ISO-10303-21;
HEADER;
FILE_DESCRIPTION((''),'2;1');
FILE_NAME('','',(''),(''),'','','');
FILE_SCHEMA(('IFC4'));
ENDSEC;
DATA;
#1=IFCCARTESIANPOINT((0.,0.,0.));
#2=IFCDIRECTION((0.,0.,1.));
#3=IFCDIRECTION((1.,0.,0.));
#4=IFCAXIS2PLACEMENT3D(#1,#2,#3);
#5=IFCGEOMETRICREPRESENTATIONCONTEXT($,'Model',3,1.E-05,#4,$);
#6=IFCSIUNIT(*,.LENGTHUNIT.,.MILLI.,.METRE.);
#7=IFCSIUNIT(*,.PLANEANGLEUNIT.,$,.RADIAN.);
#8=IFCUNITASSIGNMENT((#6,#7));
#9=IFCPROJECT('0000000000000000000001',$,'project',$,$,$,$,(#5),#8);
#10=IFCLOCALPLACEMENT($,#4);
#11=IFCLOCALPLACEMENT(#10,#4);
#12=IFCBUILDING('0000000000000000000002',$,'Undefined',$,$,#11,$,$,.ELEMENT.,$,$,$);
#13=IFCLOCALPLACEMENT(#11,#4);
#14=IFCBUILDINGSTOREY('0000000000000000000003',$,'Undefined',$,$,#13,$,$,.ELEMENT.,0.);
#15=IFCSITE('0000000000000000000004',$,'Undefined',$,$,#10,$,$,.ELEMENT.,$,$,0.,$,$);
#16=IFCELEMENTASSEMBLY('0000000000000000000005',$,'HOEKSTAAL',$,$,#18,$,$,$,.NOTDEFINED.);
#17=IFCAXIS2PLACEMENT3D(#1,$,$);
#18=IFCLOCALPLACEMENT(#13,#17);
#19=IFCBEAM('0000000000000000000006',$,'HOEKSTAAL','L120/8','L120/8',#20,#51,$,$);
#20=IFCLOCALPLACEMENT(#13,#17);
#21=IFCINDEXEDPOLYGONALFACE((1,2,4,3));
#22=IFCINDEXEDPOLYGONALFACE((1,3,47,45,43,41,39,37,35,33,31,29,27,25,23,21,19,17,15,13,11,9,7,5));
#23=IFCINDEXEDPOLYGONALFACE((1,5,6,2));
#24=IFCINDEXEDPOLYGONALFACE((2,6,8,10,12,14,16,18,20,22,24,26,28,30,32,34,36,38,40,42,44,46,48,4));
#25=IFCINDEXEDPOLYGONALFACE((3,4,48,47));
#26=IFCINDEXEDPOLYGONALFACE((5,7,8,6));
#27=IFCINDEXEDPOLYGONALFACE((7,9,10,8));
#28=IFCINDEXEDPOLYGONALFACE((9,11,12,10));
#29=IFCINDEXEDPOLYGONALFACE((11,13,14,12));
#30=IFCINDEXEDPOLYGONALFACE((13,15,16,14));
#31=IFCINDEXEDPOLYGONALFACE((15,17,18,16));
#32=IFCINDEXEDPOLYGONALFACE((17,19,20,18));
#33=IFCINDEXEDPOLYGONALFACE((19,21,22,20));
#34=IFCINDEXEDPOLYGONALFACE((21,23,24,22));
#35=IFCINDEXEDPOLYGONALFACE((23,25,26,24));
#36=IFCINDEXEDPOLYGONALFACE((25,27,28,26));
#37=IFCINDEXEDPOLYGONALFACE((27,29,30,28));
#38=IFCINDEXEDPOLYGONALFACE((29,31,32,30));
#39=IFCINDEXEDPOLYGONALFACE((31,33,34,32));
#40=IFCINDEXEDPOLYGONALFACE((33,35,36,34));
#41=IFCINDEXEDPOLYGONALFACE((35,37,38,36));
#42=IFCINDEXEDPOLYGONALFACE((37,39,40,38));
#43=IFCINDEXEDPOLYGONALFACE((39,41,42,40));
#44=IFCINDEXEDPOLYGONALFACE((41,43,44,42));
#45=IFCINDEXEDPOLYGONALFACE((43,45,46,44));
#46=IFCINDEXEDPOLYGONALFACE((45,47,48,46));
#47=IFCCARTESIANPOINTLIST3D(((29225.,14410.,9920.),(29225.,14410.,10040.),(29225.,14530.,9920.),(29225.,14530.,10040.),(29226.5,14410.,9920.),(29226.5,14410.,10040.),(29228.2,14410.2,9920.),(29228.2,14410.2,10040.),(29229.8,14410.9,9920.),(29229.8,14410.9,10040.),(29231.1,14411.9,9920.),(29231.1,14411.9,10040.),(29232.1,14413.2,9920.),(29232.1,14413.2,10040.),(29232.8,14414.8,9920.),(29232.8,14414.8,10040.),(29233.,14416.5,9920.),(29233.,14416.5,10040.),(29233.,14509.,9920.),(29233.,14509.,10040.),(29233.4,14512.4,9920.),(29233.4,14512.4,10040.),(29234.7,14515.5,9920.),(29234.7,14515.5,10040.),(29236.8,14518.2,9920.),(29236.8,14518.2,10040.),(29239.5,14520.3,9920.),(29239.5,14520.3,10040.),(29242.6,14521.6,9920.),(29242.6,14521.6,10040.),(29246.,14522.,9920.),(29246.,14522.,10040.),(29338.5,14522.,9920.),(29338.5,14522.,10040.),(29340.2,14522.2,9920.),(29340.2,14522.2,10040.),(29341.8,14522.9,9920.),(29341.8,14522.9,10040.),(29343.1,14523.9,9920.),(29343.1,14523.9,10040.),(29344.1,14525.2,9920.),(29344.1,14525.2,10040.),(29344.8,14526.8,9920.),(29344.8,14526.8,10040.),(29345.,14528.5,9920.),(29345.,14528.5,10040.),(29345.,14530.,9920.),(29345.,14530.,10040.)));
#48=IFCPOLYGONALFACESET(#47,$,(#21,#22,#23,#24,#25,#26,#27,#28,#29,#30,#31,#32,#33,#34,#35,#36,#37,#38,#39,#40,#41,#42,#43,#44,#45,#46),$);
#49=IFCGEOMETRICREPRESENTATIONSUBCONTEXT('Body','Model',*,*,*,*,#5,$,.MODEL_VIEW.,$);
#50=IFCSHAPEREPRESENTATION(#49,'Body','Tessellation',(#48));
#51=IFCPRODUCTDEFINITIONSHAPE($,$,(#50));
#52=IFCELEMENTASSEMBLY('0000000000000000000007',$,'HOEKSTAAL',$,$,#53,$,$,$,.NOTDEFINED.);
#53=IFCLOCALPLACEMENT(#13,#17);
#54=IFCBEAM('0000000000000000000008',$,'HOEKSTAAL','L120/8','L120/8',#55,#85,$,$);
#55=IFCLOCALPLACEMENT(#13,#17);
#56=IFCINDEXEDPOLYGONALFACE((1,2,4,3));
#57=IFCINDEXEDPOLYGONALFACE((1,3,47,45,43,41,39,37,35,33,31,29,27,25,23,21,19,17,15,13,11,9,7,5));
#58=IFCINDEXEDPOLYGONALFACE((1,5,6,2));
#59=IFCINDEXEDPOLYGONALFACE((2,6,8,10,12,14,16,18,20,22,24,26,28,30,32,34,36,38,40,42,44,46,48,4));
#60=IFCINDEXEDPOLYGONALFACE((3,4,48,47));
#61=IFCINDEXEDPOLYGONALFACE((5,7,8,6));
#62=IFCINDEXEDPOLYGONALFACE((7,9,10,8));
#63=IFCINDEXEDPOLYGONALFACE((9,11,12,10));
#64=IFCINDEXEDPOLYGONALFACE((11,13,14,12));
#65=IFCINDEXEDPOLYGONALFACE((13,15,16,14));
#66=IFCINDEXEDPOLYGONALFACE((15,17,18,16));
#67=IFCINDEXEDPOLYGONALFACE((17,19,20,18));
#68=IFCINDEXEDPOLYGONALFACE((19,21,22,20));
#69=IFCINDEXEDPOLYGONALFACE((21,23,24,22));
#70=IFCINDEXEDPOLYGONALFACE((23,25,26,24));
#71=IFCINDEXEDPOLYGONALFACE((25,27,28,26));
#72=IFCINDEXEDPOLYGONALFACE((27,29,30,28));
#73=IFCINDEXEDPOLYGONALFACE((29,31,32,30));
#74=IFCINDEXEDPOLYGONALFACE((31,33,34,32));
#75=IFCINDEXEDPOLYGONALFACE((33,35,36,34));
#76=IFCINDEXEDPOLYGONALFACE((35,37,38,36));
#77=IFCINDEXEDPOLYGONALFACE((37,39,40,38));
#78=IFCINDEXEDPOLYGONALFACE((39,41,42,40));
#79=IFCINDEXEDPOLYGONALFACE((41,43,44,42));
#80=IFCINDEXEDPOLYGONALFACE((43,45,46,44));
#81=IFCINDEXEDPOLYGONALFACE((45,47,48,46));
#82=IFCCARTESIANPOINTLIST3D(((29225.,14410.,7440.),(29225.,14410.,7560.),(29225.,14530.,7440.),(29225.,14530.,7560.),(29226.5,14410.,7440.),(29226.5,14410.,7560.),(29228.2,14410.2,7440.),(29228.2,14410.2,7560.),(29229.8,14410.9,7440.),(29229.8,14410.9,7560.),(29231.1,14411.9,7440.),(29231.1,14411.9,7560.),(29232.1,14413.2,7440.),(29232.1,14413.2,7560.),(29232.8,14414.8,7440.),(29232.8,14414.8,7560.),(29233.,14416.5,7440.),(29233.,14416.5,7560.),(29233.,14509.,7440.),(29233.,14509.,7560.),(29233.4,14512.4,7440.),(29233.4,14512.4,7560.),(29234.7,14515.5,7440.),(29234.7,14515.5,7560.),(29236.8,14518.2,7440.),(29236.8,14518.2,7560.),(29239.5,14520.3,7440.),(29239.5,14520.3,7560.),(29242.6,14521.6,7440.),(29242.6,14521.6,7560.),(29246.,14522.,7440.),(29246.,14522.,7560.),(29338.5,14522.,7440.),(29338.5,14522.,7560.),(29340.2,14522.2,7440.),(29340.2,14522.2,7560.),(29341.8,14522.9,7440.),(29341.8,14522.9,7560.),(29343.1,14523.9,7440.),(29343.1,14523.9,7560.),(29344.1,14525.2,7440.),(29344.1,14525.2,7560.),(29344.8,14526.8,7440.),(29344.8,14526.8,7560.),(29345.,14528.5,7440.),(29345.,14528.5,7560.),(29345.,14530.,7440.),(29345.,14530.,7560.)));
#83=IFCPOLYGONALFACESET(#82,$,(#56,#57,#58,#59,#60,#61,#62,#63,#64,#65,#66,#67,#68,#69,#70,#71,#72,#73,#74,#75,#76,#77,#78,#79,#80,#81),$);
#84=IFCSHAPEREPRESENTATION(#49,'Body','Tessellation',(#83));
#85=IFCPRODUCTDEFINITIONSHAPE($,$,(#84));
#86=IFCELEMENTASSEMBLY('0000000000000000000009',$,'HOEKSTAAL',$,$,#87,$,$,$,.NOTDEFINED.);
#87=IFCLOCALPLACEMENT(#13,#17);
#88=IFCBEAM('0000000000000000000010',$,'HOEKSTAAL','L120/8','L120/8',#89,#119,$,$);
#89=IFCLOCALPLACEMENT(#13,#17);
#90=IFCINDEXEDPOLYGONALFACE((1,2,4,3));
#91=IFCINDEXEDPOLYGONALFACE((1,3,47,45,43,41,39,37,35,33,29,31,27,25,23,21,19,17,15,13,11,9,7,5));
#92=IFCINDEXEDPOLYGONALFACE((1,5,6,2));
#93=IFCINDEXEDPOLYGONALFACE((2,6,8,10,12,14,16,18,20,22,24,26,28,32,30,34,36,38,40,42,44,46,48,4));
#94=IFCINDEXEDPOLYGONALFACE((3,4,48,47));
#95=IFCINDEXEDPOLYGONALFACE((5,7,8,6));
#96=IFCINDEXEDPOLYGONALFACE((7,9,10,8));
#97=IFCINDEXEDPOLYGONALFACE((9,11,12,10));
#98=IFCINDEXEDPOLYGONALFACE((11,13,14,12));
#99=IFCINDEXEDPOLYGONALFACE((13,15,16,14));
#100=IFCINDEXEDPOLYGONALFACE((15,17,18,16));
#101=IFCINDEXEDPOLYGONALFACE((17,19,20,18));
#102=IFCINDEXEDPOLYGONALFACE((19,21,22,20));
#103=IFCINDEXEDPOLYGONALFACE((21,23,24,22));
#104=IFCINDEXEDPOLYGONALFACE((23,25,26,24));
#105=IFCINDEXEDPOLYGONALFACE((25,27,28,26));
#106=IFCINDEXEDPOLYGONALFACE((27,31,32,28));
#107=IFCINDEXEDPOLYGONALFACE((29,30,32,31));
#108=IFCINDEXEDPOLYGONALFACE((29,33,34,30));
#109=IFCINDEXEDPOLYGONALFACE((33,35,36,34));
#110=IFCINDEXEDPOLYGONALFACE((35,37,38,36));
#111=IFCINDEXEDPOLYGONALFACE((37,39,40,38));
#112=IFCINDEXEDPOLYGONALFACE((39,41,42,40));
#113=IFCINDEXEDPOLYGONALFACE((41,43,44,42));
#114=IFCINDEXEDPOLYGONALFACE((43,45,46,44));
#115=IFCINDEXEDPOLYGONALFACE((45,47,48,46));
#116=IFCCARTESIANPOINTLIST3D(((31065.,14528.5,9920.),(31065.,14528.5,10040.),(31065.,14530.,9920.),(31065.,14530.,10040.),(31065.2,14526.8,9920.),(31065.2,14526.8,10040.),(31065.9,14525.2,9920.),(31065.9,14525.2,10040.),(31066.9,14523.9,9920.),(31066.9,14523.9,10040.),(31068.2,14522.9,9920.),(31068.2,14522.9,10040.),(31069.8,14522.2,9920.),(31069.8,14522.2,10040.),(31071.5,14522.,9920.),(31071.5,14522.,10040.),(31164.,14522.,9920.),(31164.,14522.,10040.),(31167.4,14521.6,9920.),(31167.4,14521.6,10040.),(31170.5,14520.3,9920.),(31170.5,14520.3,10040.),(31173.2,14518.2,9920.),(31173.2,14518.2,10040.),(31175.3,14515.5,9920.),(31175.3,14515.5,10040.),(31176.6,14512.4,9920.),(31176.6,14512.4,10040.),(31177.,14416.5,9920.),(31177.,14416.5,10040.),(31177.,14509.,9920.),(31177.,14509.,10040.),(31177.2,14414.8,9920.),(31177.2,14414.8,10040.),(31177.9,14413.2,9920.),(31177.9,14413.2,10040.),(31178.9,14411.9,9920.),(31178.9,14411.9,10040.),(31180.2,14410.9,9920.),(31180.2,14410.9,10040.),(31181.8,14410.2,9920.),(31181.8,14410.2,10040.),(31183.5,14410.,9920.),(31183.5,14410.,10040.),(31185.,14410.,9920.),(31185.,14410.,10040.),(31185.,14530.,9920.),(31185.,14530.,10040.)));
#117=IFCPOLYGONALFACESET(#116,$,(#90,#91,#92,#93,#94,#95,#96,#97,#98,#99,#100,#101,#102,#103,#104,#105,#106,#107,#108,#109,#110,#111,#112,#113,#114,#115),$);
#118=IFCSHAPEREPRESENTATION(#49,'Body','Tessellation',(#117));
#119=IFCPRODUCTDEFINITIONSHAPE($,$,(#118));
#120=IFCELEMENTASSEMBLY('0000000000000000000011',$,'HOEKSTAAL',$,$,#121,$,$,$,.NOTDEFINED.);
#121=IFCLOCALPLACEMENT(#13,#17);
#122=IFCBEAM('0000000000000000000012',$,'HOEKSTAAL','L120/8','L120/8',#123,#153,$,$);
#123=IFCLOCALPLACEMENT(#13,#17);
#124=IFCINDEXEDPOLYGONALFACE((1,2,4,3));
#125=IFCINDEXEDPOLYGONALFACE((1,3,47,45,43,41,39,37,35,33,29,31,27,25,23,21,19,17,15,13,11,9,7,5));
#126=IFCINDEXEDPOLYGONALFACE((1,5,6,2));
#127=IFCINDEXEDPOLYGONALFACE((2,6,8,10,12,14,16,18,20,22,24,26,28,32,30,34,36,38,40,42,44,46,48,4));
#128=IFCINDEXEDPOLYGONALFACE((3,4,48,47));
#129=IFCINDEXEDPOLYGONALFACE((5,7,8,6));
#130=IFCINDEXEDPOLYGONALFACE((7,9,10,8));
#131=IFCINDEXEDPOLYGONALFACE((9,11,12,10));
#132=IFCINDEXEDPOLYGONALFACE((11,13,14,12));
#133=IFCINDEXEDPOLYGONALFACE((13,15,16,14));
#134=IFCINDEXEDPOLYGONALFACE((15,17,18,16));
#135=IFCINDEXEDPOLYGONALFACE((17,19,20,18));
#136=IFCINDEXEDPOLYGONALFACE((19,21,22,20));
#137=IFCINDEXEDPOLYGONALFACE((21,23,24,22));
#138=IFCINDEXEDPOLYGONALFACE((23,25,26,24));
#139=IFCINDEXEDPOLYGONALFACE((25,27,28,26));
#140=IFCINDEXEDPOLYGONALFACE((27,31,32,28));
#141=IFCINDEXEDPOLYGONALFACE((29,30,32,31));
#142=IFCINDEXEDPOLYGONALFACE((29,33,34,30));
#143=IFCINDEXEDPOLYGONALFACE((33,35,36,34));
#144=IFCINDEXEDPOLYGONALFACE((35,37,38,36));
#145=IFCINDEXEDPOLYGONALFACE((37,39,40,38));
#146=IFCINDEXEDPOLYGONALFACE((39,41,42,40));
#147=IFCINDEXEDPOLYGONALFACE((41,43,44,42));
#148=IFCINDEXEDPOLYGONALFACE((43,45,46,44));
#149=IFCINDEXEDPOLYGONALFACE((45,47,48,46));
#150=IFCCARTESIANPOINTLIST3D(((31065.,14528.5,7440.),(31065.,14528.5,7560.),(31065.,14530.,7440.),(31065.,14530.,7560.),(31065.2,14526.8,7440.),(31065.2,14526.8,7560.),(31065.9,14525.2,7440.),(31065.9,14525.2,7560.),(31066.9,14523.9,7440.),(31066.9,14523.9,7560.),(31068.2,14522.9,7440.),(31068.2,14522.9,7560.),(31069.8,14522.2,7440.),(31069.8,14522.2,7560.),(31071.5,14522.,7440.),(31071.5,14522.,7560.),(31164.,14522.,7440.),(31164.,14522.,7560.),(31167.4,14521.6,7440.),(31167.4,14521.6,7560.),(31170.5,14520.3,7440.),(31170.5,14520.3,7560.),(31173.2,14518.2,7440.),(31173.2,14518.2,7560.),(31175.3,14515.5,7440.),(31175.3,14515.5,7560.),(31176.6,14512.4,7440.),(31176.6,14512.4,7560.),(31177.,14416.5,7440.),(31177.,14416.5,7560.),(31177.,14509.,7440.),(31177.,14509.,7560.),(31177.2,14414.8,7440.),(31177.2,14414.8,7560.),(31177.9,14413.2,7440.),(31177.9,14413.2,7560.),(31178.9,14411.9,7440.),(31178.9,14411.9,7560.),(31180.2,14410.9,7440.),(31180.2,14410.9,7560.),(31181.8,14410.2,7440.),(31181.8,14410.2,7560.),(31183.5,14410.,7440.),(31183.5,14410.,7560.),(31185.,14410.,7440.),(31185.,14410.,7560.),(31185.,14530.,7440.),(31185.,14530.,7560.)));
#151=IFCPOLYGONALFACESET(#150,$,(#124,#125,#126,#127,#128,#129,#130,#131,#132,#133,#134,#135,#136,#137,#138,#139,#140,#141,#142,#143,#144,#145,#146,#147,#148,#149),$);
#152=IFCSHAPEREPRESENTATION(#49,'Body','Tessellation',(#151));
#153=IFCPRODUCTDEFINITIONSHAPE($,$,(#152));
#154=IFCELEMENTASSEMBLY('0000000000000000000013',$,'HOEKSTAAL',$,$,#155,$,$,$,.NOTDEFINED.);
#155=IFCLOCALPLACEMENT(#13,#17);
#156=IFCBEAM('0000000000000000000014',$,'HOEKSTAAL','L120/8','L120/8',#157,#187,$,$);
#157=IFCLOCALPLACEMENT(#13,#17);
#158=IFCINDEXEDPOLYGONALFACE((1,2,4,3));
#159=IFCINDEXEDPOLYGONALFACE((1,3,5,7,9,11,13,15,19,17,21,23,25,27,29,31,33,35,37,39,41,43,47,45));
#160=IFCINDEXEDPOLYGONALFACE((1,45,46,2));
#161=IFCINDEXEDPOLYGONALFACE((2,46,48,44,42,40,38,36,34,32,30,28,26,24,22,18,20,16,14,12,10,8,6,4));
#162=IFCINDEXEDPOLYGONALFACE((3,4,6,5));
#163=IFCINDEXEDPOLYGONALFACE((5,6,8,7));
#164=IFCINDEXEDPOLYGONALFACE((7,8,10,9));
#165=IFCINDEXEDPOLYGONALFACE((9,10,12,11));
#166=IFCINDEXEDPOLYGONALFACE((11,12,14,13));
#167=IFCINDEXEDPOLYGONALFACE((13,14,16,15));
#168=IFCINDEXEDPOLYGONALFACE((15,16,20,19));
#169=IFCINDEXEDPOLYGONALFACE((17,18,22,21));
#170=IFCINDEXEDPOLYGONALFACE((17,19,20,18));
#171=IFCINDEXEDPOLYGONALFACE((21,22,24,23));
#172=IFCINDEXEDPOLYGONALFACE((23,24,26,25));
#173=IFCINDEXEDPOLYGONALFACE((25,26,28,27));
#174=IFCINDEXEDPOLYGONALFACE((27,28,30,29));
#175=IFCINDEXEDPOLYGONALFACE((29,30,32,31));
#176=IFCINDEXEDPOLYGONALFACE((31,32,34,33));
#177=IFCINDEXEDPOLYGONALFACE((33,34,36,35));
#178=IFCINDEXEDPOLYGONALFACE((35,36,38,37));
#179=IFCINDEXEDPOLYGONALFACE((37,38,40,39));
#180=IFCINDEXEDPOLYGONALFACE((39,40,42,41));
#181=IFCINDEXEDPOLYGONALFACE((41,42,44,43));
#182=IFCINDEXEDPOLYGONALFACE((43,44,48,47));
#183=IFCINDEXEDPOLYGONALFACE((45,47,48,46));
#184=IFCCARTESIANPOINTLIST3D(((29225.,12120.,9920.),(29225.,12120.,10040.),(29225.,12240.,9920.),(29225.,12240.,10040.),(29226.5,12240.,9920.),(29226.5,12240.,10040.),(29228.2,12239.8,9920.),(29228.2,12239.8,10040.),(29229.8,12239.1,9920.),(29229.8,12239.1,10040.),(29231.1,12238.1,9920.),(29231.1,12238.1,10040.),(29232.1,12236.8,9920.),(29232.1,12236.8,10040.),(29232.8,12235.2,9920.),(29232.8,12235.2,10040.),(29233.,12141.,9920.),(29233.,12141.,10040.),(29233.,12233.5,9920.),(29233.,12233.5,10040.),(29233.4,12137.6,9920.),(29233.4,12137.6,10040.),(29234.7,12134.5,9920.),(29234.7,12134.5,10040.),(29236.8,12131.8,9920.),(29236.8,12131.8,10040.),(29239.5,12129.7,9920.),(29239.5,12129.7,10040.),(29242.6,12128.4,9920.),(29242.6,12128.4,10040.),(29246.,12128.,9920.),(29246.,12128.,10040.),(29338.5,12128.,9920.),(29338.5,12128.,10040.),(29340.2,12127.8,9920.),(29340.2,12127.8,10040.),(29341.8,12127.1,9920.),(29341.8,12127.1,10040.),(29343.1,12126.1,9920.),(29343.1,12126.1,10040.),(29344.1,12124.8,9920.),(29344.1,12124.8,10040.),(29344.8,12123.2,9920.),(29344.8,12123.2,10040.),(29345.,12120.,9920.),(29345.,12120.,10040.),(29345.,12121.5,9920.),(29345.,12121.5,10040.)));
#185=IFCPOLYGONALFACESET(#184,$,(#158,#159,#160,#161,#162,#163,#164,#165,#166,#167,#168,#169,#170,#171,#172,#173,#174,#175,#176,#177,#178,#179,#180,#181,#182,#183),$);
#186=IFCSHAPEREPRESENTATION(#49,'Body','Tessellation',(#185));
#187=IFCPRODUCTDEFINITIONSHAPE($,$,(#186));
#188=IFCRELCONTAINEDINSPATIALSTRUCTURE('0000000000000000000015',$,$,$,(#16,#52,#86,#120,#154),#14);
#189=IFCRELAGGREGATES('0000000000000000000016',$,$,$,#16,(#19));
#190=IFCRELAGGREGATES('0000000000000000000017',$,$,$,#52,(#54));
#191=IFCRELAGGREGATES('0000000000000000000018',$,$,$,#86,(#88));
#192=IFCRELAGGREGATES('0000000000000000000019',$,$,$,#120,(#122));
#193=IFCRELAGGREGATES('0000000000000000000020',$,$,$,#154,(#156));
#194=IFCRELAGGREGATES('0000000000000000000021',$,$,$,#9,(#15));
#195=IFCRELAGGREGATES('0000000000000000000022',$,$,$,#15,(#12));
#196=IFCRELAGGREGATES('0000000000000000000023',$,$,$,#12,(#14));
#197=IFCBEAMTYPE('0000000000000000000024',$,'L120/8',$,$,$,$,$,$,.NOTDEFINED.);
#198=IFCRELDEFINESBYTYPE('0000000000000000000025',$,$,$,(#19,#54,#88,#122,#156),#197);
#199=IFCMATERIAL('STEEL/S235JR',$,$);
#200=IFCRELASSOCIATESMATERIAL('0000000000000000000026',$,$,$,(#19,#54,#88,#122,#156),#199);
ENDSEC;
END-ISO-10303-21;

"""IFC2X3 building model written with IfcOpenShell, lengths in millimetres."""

from ifc_helpers import new_model, si_unit, frame, origin_with_axes, origin_2d_with_axis, place, context, subcontext, project, spatial, l_section, extrude, material, type_object, element, aggregate, save


model = new_model("IFC2X3")

# Units and contexts
model_context = context("Model", 3, precision=1e-05, world=origin_with_axes())
body_context = subcontext(model_context, "Body", "Model", "MODEL_VIEW")
ifc_project = project(units=[si_unit("LENGTHUNIT", "METRE", prefix="MILLI"), si_unit("PLANEANGLEUNIT", "RADIAN")], contexts=[model_context])

# Site, building, storey
site_placement = place(None, origin_with_axes())
site = spatial("IfcSite", under=ifc_project, at=site_placement, Name="Undefined", CompositionType="ELEMENT", RefElevation=0.0)
building_placement = place(site_placement, origin_with_axes())
building = spatial("IfcBuilding", under=site, at=building_placement, Name="Undefined", CompositionType="ELEMENT")
storey_placement = place(building_placement, origin_with_axes())
storey = spatial("IfcBuildingStorey", under=building, at=storey_placement, Name="Undefined", CompositionType="ELEMENT", Elevation=0.0)

# Element assemblies, beams
assembly_1_placement = place(storey_placement, origin_with_axes())
assembly_1 = element("IfcElementAssembly", 1, at=assembly_1_placement, inside=storey, Name="HOEKSTAAL", PredefinedType="NOTDEFINED")
ifc_material_1 = material(Name="STEEL/S235JR")
beam_type_1 = type_object("IfcBeamType", Name="L120/8", PredefinedType="NOTDEFINED")
beam_1_placement = place(assembly_1_placement, frame((29285.0, 14470.0, 10040.0), z_axis=(1.0, 0.0, 0.0), x_axis=(0.0, 0.0, -1.0)))
beam_1 = element("IfcBeam", 2, at=beam_1_placement, type_object=beam_type_1, material=ifc_material_1, Name="HOEKSTAAL", Description="L120/8", ObjectType="L120/8", context=body_context, shape_type="SweptSolid", body=[
    extrude(l_section(Depth=120.0, Width=120.0, Thickness=8.0, FilletRadius=13.0, EdgeRadius=6.5, at=origin_2d_with_axis()), frame((120.0, 0.0, 0.0), z_axis=(-1.0, 0.0, 0.0), x_axis=(0.0, -1.0, 0.0)), (0.0, 0.0, 1.0), 120.0),
])
aggregate(assembly_1, [beam_1])
assembly_2_placement = place(storey_placement, origin_with_axes())
assembly_2 = element("IfcElementAssembly", 3, at=assembly_2_placement, inside=storey, Name="HOEKSTAAL", PredefinedType="NOTDEFINED")
beam_2_placement = place(assembly_2_placement, frame((29285.0, 14470.0, 7560.0), z_axis=(1.0, 0.0, 0.0), x_axis=(0.0, 0.0, -1.0)))
beam_2 = element("IfcBeam", 4, at=beam_2_placement, type_object=beam_type_1, material=ifc_material_1, Name="HOEKSTAAL", Description="L120/8", ObjectType="L120/8", context=body_context, shape_type="SweptSolid", body=[
    extrude(l_section(Depth=120.0, Width=120.0, Thickness=8.0, FilletRadius=13.0, EdgeRadius=6.5, at=origin_2d_with_axis()), frame((120.0, 0.0, 0.0), z_axis=(-1.0, 0.0, 0.0), x_axis=(0.0, -1.0, 0.0)), (0.0, 0.0, 1.0), 120.0),
])
aggregate(assembly_2, [beam_2])
assembly_3_placement = place(storey_placement, origin_with_axes())
assembly_3 = element("IfcElementAssembly", 5, at=assembly_3_placement, inside=storey, Name="HOEKSTAAL", PredefinedType="NOTDEFINED")
beam_3_placement = place(assembly_3_placement, frame((31125.0, 14470.0, 9920.0), z_axis=(-1.0, 0.0, 0.0), x_axis=(0.0, 0.0, 1.0)))
beam_3 = element("IfcBeam", 6, at=beam_3_placement, type_object=beam_type_1, material=ifc_material_1, Name="HOEKSTAAL", Description="L120/8", ObjectType="L120/8", context=body_context, shape_type="SweptSolid", body=[
    extrude(l_section(Depth=120.0, Width=120.0, Thickness=8.0, FilletRadius=13.0, EdgeRadius=6.5, at=origin_2d_with_axis()), frame((120.0, 0.0, 0.0), z_axis=(-1.0, 0.0, 0.0), x_axis=(0.0, -1.0, 0.0)), (0.0, 0.0, 1.0), 120.0),
])
aggregate(assembly_3, [beam_3])
assembly_4_placement = place(storey_placement, origin_with_axes())
assembly_4 = element("IfcElementAssembly", 7, at=assembly_4_placement, inside=storey, Name="HOEKSTAAL", PredefinedType="NOTDEFINED")
beam_4_placement = place(assembly_4_placement, frame((31125.0, 14470.0, 7440.0), z_axis=(-1.0, 0.0, 0.0), x_axis=(0.0, 0.0, 1.0)))
beam_4 = element("IfcBeam", 8, at=beam_4_placement, type_object=beam_type_1, material=ifc_material_1, Name="HOEKSTAAL", Description="L120/8", ObjectType="L120/8", context=body_context, shape_type="SweptSolid", body=[
    extrude(l_section(Depth=120.0, Width=120.0, Thickness=8.0, FilletRadius=13.0, EdgeRadius=6.5, at=origin_2d_with_axis()), frame((120.0, 0.0, 0.0), z_axis=(-1.0, 0.0, 0.0), x_axis=(0.0, -1.0, 0.0)), (0.0, 0.0, 1.0), 120.0),
])
aggregate(assembly_4, [beam_4])
assembly_5_placement = place(storey_placement, origin_with_axes())
assembly_5 = element("IfcElementAssembly", 9, at=assembly_5_placement, inside=storey, Name="HOEKSTAAL", PredefinedType="NOTDEFINED")
beam_5_placement = place(assembly_5_placement, frame((29285.0, 12180.0, 9920.0), z_axis=(1.0, 0.0, 0.0), x_axis=(0.0, 0.0, 1.0)))
beam_5 = element("IfcBeam", 10, at=beam_5_placement, type_object=beam_type_1, material=ifc_material_1, Name="HOEKSTAAL", Description="L120/8", ObjectType="L120/8", context=body_context, shape_type="SweptSolid", body=[
    extrude(l_section(Depth=120.0, Width=120.0, Thickness=8.0, FilletRadius=13.0, EdgeRadius=6.5, at=origin_2d_with_axis()), frame((120.0, 0.0, 0.0), z_axis=(-1.0, 0.0, 0.0), x_axis=(0.0, -1.0, 0.0)), (0.0, 0.0, 1.0), 120.0),
])
aggregate(assembly_5, [beam_5])

save(model, "model.ifc")
